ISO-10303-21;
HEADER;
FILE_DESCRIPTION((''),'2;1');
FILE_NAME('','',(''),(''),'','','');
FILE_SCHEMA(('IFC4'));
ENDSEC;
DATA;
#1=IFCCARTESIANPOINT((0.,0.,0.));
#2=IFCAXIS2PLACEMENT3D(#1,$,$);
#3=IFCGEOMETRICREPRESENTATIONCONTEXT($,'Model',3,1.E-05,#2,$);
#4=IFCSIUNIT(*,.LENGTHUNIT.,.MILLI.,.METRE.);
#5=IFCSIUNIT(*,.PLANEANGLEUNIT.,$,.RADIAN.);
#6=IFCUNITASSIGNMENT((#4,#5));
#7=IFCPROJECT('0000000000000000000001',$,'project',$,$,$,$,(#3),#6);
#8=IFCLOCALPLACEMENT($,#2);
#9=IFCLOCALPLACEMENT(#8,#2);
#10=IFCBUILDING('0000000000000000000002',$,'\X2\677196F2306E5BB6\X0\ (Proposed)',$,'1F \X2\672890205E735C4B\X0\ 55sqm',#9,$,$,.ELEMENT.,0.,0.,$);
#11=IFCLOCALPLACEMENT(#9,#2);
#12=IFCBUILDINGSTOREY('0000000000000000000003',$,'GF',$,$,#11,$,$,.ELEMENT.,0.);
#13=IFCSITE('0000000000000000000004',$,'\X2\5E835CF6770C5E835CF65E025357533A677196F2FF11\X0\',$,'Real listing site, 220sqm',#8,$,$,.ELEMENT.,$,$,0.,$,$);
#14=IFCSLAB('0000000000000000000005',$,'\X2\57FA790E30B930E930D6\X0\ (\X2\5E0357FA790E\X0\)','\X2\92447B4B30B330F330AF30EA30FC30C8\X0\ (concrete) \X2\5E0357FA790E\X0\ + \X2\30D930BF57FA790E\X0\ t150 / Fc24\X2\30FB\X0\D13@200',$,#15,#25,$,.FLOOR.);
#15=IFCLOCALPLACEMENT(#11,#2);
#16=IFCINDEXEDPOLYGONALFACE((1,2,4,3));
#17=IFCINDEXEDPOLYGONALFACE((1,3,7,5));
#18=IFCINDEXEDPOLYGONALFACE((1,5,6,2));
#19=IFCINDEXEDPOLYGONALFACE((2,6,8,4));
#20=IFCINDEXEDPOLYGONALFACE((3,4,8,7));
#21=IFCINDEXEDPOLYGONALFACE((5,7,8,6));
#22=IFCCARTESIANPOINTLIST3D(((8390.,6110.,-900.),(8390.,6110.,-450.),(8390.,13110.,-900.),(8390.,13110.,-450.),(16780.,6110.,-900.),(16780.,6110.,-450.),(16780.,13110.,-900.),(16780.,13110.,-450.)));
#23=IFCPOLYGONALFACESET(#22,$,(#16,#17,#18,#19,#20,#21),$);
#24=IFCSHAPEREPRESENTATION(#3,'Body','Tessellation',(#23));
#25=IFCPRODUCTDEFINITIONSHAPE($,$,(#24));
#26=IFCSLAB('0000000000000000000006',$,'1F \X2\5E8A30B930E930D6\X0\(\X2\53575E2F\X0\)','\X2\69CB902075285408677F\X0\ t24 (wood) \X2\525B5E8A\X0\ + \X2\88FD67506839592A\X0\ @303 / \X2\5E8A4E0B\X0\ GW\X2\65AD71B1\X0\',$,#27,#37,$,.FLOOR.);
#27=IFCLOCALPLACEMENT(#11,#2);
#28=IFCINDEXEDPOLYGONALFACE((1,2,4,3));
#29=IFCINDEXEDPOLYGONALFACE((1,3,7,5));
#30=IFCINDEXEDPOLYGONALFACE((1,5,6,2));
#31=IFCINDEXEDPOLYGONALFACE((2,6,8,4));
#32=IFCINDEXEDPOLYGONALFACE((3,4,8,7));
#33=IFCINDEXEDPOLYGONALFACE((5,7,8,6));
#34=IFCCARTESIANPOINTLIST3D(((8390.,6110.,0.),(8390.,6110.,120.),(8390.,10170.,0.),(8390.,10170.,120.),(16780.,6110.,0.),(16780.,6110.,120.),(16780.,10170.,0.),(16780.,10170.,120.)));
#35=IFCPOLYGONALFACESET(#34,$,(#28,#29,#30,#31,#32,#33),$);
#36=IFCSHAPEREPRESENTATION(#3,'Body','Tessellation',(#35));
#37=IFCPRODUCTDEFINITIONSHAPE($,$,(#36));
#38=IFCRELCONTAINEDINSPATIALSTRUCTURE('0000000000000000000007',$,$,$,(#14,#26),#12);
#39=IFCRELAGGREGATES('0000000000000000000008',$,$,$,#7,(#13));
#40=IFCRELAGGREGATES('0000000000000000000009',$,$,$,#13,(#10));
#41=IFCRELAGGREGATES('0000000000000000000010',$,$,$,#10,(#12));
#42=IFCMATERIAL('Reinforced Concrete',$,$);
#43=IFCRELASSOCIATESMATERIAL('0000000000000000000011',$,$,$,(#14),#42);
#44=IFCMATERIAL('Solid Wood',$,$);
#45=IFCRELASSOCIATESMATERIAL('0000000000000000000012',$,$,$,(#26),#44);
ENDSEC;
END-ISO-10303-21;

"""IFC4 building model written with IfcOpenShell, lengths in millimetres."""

from ifc_helpers import new_model, si_unit, frame, frame_2d, origin, place, context, project, spatial, rectangle, extrude, material, element, save


model = new_model("IFC4")

# Units and contexts
model_context = context("Model", 3, precision=1e-05, world=origin())
ifc_project = project(units=[si_unit("LENGTHUNIT", "METRE", prefix="MILLI"), si_unit("PLANEANGLEUNIT", "RADIAN")], contexts=[model_context])

# Site, building, storey
site_placement = place(None, origin())
site = spatial("IfcSite", under=ifc_project, at=site_placement, Name="広島県広島市南区東雲１", ObjectType="Real listing site, 220sqm", CompositionType="ELEMENT", RefElevation=0.0)
building_placement = place(site_placement, origin())
building = spatial("IfcBuilding", under=site, at=building_placement, Name="東雲の家 (Proposed)", ObjectType="1F 木造平屋 55sqm", CompositionType="ELEMENT", ElevationOfRefHeight=0.0, ElevationOfTerrain=0.0)
storey_placement = place(building_placement, origin())
storey = spatial("IfcBuildingStorey", under=building, at=storey_placement, Name="GF", CompositionType="ELEMENT", Elevation=0.0)

# Shared definitions
ifc_material_1 = material(Name="Solid Wood")

# Slabs
ifc_material_2 = material(Name="Reinforced Concrete")
slab_1_placement = place(storey_placement, frame((4195.0, 3055.0, -450.0)))
element("IfcSlab", 1, at=slab_1_placement, inside=storey, material=ifc_material_2, Name="基礎スラブ (布基礎)", Description="鉄筋コンクリート (concrete) 布基礎 + ベタ基礎 t150 / Fc24・D13@200", PredefinedType="FLOOR", context=model_context, shape_type="SweptSolid", body=[
    extrude(rectangle(XDim=8390.0, YDim=7000.0, at=frame_2d((4195.0, 3500.0))), frame((4195.0, 3055.0, -450.0)), (0.0, 0.0, 1.0), 450.0),
])
slab_2_placement = place(storey_placement, frame((4195.0, 3055.0, 0.0)))
element("IfcSlab", 2, at=slab_2_placement, inside=storey, material=ifc_material_1, Name="1F 床スラブ(南帯)", Description="構造用合板 t24 (wood) 剛床 + 製材根太 @303 / 床下 GW断熱", PredefinedType="FLOOR", context=model_context, shape_type="SweptSolid", body=[
    extrude(rectangle(XDim=8390.0, YDim=4060.0, at=frame_2d((4195.0, 2030.0))), frame((4195.0, 3055.0, 0.0)), (0.0, 0.0, 1.0), 120.0),
])

save(model, "model.ifc")
